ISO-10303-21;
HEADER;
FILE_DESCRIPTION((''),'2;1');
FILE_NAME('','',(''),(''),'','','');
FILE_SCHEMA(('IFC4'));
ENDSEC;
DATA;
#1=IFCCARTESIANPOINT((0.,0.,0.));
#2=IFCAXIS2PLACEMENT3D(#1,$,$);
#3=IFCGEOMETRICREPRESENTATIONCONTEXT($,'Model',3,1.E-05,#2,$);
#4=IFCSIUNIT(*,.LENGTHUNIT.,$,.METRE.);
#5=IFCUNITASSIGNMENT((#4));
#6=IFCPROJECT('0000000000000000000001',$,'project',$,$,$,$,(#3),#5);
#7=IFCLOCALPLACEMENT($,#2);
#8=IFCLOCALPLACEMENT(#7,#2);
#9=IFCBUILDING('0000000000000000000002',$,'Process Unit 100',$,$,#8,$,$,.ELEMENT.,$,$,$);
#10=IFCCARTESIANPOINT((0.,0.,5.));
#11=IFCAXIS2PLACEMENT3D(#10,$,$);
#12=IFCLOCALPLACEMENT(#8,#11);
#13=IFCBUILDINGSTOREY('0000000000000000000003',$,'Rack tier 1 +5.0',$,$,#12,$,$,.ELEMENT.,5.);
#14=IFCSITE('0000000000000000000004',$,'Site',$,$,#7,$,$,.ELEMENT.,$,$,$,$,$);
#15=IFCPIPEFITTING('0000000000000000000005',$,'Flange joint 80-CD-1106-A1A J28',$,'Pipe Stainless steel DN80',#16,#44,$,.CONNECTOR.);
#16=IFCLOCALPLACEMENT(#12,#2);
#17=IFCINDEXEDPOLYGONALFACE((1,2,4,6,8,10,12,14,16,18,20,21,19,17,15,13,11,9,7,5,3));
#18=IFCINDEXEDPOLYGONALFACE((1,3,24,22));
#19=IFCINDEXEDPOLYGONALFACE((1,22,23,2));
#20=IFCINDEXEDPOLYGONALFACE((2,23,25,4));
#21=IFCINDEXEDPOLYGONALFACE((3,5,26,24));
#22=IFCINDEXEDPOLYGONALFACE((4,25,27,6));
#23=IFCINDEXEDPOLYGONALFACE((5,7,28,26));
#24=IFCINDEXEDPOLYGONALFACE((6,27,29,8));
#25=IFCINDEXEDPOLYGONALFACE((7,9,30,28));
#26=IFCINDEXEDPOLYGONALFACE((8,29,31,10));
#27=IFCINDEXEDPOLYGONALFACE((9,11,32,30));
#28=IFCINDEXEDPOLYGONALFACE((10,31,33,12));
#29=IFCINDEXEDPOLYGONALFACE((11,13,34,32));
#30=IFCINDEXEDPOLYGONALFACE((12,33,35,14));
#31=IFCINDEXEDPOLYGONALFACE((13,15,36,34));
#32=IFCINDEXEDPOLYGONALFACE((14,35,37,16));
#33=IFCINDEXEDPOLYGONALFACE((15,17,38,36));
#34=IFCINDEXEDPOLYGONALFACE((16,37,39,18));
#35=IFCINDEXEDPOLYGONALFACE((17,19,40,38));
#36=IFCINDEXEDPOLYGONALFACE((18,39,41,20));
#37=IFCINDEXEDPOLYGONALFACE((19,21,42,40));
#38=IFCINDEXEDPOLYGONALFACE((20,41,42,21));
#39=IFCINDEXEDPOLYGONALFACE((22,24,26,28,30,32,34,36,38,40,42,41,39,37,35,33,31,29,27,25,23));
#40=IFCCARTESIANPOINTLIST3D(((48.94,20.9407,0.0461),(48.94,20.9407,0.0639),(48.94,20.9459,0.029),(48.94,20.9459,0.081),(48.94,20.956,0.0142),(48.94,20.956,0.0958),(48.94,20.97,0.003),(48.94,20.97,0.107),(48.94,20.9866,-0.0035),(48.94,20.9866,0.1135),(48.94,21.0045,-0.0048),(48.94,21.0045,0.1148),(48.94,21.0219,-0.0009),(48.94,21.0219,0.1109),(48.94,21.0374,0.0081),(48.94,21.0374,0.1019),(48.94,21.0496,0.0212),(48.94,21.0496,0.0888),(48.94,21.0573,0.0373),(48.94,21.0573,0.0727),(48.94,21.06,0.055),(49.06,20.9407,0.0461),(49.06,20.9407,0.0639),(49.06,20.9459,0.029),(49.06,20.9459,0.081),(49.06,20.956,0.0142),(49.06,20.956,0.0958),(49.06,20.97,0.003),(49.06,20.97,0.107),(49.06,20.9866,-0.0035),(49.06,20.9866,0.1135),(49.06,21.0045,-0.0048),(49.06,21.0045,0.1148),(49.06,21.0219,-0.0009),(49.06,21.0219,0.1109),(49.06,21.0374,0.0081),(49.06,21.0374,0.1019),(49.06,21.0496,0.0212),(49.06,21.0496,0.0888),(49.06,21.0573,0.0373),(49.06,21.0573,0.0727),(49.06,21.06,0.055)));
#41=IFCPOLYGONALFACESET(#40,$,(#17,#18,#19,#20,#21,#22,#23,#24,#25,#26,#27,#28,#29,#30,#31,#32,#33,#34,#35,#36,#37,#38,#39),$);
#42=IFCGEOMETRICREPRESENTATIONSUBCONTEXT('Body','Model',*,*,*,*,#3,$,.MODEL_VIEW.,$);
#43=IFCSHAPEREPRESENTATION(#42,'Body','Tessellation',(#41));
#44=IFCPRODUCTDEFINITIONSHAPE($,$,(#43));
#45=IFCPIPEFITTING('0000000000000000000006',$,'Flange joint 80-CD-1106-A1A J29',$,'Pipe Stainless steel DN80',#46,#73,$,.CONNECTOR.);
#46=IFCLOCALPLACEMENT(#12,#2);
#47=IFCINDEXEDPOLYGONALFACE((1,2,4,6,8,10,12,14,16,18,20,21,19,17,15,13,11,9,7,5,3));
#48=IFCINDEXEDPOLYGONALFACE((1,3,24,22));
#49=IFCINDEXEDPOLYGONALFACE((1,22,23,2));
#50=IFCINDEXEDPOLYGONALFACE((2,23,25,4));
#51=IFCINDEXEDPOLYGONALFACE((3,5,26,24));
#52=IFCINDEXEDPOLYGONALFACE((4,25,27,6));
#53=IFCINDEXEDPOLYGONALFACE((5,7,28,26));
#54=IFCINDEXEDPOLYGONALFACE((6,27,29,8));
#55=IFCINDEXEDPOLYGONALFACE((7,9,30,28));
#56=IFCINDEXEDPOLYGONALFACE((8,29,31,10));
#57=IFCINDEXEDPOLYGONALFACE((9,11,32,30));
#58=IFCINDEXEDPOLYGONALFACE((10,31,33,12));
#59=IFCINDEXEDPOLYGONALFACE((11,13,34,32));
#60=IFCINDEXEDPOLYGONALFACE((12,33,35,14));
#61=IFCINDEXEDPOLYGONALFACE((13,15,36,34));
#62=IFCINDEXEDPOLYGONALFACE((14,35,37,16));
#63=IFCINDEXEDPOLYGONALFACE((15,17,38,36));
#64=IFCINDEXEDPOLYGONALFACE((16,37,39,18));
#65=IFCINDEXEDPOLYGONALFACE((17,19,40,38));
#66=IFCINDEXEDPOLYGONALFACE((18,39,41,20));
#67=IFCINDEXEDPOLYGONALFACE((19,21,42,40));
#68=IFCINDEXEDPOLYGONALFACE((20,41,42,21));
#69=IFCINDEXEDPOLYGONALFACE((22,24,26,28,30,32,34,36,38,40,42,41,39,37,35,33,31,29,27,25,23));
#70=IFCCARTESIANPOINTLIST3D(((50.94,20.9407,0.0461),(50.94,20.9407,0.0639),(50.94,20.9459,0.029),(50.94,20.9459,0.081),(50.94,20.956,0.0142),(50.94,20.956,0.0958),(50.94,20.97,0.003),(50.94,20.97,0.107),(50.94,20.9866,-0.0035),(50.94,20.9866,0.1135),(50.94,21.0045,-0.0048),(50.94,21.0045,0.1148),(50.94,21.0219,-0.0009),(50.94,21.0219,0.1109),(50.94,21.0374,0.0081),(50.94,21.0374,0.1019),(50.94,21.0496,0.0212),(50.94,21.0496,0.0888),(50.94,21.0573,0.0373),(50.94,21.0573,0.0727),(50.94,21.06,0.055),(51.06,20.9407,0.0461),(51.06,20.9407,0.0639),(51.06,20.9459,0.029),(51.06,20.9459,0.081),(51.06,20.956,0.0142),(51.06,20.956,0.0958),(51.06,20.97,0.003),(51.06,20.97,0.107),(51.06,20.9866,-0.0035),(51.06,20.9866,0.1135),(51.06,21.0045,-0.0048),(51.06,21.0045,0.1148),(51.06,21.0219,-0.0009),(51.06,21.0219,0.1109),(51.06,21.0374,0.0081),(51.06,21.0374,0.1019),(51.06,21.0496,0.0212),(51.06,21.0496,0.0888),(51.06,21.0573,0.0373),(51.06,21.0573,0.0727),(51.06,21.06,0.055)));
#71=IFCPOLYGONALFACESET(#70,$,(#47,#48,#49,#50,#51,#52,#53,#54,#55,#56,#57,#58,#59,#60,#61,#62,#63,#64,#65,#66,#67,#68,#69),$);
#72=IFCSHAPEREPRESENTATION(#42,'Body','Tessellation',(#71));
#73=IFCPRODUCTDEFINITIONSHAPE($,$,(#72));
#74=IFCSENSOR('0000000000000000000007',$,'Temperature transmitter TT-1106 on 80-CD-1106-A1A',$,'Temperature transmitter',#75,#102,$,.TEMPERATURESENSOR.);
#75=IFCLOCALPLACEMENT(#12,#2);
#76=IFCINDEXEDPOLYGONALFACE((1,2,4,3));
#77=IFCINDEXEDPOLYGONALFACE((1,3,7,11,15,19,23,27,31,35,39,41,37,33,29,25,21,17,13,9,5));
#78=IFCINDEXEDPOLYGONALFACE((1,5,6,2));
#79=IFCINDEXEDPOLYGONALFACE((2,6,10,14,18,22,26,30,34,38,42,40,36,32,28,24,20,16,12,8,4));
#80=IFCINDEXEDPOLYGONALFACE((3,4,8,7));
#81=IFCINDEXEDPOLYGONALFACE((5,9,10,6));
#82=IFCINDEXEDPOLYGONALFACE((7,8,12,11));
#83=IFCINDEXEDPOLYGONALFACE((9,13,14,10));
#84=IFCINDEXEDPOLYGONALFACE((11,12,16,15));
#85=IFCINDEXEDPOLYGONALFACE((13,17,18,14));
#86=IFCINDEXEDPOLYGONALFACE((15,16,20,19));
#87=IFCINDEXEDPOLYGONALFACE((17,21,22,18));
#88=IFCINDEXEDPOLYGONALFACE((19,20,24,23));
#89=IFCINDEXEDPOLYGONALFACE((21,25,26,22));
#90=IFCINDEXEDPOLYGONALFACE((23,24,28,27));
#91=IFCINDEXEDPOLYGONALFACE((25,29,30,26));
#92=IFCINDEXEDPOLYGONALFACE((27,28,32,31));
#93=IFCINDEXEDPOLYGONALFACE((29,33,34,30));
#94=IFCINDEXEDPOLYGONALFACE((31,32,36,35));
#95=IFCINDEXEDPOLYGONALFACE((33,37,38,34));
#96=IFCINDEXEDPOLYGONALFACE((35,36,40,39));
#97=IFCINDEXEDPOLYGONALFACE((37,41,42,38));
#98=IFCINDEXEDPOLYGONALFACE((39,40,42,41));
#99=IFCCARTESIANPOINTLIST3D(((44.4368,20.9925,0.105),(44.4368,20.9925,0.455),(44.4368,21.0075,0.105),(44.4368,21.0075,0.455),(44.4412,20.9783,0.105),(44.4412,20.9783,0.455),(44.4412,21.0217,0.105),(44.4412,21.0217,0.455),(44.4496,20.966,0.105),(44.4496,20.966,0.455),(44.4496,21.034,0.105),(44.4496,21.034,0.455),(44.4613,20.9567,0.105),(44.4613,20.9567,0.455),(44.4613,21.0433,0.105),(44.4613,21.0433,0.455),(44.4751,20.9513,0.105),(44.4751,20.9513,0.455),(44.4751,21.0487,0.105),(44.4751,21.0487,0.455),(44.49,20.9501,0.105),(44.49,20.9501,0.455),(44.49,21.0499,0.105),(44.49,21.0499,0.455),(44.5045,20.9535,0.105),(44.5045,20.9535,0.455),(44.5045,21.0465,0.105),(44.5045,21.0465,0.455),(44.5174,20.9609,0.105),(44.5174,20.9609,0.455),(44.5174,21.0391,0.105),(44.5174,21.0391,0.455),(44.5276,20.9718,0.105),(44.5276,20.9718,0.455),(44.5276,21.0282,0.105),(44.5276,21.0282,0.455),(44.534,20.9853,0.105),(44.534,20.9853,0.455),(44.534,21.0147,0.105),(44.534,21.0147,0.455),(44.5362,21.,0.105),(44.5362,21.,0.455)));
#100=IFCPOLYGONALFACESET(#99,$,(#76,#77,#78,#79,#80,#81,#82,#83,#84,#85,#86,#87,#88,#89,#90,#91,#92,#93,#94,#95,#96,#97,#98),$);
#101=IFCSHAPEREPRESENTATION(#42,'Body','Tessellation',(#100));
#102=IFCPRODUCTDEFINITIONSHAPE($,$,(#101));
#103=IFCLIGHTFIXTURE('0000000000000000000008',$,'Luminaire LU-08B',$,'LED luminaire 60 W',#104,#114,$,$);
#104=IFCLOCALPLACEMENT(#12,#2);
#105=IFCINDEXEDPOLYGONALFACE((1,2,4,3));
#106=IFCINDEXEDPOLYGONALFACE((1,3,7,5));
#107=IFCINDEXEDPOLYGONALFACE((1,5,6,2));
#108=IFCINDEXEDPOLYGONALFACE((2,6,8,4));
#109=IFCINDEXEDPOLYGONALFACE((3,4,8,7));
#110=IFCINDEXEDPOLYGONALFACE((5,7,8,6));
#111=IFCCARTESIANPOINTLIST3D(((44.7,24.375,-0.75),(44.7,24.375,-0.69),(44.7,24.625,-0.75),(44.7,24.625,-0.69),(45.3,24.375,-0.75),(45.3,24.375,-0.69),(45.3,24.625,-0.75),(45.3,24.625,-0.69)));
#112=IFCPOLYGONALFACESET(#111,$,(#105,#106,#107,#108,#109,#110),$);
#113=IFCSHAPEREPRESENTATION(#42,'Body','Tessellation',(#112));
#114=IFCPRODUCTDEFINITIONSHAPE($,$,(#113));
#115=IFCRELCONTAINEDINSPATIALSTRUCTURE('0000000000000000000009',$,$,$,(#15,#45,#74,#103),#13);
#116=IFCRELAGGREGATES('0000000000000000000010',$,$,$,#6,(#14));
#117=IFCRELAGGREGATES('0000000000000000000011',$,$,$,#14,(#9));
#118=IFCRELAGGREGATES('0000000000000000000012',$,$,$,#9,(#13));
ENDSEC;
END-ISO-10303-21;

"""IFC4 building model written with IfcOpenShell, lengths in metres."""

from ifc_helpers import new_model, si_unit, frame, origin, place, context, subcontext, project, spatial, rectangle, circle, extrude, element, save


model = new_model("IFC4")

# Units and contexts
model_context = context("Model", 3, precision=1e-05, world=origin())
body_context = subcontext(model_context, "Body", "Model", "MODEL_VIEW")
ifc_project = project(units=[si_unit("LENGTHUNIT", "METRE")], contexts=[model_context])

# Site, building, storey
site_placement = place(None, origin())
site = spatial("IfcSite", under=ifc_project, at=site_placement, Name="Site", CompositionType="ELEMENT")
building_placement = place(site_placement, origin())
building = spatial("IfcBuilding", under=site, at=building_placement, Name="Process Unit 100", CompositionType="ELEMENT")
storey_placement = place(building_placement, frame((0.0, 0.0, 5.0)))
storey = spatial("IfcBuildingStorey", under=building, at=storey_placement, Name="Rack tier 1 +5.0", CompositionType="ELEMENT", Elevation=5.0)

# Pipe fittings
for number, where, z_axis, x_axis, name in (
    (1, (48.94, 21.0, 0.055), (1.0, 0.0, 0.0), (0.0, 1.0, 0.0), "Flange joint 80-CD-1106-A1A J28"),
    (2, (50.94, 21.0, 0.055), (1.0, 0.0, 0.0), (0.0, 1.0, 0.0), "Flange joint 80-CD-1106-A1A J29"),
):
    element("IfcPipeFitting", number, at=place(storey_placement, frame(where, z_axis=z_axis, x_axis=x_axis)), inside=storey, Name=name, ObjectType="Pipe Stainless steel DN80", PredefinedType="CONNECTOR", context=body_context, shape_type="SweptSolid", body=[
        extrude(circle(Radius=0.06), origin(), (0.0, 0.0, 1.0), 0.12),
    ])

# Sensor
sensor_1_placement = place(storey_placement, frame((44.4863, 21.0, 0.105), z_axis=(0.0, 0.0, 1.0), x_axis=(1.0, 0.0, 0.0)))
element("IfcSensor", 3, at=sensor_1_placement, inside=storey, Name="Temperature transmitter TT-1106 on 80-CD-1106-A1A", ObjectType="Temperature transmitter", PredefinedType="TEMPERATURESENSOR", context=body_context, shape_type="SweptSolid", body=[
    extrude(circle(Radius=0.05), origin(), (0.0, 0.0, 1.0), 0.35),
])

# Light fixture
light_fixture_placement = place(storey_placement, frame((45.0, 24.5, -0.75), z_axis=(0.0, 0.0, 1.0), x_axis=(1.0, 0.0, 0.0)))
element("IfcLightFixture", 4, at=light_fixture_placement, inside=storey, Name="Luminaire LU-08B", ObjectType="LED luminaire 60 W", context=body_context, shape_type="SweptSolid", body=[
    extrude(rectangle(XDim=0.6, YDim=0.25), origin(), (0.0, 0.0, 1.0), 0.06),
])

save(model, "model.ifc")
